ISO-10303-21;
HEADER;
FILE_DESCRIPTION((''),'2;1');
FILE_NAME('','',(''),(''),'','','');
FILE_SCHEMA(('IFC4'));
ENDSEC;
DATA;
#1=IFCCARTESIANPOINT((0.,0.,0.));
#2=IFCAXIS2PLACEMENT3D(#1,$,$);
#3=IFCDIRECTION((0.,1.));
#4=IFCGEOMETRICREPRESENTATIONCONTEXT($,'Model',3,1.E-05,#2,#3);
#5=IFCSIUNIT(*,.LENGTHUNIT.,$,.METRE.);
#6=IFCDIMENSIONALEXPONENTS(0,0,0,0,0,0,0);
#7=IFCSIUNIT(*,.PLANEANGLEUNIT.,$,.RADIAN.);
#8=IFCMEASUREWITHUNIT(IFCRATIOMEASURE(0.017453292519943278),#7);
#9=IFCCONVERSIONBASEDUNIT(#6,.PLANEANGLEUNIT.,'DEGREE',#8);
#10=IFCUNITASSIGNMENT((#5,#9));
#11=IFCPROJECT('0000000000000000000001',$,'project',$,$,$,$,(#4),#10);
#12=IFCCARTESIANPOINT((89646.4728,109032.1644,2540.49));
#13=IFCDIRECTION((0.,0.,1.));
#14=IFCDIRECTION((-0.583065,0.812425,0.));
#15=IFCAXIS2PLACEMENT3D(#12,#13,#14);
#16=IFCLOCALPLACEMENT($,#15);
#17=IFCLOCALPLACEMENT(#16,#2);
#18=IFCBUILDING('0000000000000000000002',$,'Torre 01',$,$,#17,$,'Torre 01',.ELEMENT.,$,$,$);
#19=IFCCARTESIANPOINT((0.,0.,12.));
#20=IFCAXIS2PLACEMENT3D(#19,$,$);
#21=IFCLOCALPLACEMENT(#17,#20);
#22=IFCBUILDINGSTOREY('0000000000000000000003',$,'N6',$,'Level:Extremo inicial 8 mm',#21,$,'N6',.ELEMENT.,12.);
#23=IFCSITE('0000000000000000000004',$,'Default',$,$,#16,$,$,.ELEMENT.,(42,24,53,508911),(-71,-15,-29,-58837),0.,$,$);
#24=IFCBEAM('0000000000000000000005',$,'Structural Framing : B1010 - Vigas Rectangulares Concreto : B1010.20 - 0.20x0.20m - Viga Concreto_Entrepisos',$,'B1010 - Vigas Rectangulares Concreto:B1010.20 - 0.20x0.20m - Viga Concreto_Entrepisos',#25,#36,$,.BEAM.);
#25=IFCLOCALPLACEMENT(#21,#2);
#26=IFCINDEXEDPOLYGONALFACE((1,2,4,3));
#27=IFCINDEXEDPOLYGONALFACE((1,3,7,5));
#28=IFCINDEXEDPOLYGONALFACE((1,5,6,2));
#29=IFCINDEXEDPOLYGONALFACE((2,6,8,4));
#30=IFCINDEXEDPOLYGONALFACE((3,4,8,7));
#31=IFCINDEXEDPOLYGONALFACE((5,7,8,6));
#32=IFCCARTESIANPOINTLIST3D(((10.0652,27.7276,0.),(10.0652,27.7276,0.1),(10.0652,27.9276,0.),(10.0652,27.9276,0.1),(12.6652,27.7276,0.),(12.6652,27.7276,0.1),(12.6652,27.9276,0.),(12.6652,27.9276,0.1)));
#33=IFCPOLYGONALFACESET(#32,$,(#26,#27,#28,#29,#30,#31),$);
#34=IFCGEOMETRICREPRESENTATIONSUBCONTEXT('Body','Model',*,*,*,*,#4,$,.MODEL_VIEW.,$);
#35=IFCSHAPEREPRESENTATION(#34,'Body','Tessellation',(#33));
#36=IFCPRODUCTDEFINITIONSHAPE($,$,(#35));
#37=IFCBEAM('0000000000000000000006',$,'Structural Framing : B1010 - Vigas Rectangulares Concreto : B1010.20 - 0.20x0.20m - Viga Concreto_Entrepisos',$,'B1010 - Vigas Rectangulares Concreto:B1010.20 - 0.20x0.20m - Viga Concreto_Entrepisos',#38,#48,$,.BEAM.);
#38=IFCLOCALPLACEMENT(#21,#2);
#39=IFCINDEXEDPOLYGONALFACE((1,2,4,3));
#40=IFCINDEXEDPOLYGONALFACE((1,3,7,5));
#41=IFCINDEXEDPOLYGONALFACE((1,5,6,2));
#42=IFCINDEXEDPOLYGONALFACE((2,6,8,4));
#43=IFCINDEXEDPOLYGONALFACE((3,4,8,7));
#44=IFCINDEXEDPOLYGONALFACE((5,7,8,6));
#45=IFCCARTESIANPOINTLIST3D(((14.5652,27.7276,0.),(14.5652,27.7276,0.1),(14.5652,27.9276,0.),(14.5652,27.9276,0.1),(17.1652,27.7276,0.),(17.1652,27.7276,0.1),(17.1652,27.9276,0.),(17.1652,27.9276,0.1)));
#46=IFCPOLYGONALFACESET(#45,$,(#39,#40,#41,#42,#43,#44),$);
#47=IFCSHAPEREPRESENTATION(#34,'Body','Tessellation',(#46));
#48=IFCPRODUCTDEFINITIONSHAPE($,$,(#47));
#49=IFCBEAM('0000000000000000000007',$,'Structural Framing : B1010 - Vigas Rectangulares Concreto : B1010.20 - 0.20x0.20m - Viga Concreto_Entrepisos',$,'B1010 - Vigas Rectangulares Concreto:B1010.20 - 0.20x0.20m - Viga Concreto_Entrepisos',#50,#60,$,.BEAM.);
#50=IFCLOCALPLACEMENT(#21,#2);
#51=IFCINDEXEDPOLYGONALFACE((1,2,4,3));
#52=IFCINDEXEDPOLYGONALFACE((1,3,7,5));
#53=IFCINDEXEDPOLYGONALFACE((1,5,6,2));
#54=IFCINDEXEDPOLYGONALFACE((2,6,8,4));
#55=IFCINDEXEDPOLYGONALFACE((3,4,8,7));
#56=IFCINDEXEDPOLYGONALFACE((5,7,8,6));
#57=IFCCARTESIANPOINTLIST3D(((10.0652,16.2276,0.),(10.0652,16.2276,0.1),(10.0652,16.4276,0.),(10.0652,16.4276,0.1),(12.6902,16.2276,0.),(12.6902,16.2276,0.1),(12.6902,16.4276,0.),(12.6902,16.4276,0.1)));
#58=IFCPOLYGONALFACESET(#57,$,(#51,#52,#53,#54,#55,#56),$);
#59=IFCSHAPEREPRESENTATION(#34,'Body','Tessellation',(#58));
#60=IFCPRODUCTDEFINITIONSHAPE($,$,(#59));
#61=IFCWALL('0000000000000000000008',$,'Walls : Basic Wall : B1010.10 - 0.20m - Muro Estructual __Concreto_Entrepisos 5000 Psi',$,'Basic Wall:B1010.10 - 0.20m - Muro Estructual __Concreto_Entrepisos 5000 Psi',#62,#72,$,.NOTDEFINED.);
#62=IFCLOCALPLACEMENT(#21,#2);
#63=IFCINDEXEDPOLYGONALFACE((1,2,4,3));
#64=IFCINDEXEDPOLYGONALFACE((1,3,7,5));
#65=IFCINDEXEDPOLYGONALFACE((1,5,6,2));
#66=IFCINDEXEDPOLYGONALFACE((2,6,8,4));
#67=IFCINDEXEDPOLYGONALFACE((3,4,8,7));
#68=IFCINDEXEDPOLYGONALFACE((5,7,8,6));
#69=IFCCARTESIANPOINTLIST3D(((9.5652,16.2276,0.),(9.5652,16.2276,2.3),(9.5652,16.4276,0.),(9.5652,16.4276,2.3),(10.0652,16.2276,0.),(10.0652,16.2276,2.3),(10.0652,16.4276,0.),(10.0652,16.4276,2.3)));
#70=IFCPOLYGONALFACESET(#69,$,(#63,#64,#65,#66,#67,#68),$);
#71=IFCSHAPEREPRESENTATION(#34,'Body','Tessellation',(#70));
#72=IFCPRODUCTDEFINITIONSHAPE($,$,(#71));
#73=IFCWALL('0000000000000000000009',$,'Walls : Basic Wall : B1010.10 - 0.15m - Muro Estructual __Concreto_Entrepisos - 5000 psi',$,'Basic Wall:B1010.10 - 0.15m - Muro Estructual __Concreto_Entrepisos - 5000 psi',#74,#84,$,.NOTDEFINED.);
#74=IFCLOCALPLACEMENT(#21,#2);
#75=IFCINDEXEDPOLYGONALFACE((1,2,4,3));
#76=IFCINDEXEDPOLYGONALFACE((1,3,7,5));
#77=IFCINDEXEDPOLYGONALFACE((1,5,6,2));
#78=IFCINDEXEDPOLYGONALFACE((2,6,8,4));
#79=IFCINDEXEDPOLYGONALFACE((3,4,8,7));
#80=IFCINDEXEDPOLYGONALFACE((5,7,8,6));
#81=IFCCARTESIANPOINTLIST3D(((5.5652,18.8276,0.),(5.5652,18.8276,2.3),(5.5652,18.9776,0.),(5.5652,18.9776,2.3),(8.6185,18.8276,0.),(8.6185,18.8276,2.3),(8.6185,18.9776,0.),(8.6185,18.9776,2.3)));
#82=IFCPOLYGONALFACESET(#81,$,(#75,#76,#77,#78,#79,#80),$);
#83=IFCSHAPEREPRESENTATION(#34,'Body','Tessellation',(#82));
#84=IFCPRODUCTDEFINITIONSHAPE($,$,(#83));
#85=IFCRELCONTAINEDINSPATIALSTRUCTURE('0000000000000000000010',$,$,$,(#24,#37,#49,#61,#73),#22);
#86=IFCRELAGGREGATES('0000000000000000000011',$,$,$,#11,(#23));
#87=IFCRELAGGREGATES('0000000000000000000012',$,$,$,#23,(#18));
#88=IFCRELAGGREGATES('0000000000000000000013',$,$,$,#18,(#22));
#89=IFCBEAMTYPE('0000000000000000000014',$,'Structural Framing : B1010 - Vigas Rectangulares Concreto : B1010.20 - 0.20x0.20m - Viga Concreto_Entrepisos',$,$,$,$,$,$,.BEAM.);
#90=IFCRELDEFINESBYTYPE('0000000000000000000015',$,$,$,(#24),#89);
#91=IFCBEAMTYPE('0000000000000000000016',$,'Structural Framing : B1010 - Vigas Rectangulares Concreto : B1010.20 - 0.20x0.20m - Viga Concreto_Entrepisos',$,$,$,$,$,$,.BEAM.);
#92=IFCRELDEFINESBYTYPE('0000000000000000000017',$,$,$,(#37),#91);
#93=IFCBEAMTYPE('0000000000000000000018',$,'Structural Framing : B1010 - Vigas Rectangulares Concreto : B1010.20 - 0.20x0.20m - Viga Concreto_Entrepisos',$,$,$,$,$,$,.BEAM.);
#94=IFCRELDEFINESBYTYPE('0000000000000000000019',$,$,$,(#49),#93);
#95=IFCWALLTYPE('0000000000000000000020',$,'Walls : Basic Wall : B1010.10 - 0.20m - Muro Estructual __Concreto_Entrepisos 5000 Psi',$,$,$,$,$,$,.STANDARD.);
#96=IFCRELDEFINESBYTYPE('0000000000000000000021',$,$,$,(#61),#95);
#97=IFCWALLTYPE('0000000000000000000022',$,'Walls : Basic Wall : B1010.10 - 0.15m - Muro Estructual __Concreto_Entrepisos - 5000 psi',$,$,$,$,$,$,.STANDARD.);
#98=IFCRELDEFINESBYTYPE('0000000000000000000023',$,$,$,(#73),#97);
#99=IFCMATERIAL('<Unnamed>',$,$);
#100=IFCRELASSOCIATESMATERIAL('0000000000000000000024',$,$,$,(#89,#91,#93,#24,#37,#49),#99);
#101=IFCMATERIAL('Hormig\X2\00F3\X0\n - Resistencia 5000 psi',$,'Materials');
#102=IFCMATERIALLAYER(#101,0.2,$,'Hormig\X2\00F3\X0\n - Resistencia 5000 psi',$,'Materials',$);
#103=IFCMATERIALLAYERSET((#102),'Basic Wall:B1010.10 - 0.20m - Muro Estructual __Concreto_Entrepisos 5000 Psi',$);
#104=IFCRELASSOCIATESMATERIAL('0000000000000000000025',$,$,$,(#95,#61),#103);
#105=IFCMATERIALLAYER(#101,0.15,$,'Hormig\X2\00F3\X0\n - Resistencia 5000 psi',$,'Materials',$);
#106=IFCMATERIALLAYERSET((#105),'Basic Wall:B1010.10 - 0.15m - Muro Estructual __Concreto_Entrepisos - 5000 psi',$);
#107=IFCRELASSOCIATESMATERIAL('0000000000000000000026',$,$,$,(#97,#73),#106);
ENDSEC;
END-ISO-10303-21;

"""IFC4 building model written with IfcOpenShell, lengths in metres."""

from ifc_helpers import new_model, entity, si_unit, converted_unit, direction, frame, frame_2d, origin, place, context, subcontext, project, spatial, polyline, segment, composite_curve, rectangle, outline, extrude, source, transform, mapped, material, layer, layer_set, layer_usage, material_profile, profile_set, profile_usage, type_object, type_shapes, element, save


model = new_model("IFC4")

# Units and contexts
model_context = context("Model", 3, precision=1e-05, world=origin(), true_north=direction((0.0, 1.0)))
body_context = subcontext(model_context, "Body", "Model", "MODEL_VIEW")
ifc_project = project(units=[si_unit("LENGTHUNIT", "METRE"), converted_unit("PLANEANGLEUNIT", "DEGREE", entity("IfcRatioMeasure", 0.017453292519943278), si_unit("PLANEANGLEUNIT", "RADIAN"), dimensions=[0, 0, 0, 0, 0, 0, 0])], contexts=[model_context])

# Site, building, storey
site_placement = place(None, frame((89646.4728, 109032.1644, 2540.49), z_axis=(0.0, 0.0, 1.0), x_axis=(-0.583065, 0.812425, 0.0)))
site = spatial("IfcSite", under=ifc_project, at=site_placement, Name="Default", CompositionType="ELEMENT", RefLatitude=(42, 24, 53, 508911), RefLongitude=(-71, -15, -29, -58837), RefElevation=0.0)
building_placement = place(site_placement, origin())
building = spatial("IfcBuilding", under=site, at=building_placement, Name="Torre 01", LongName="Torre 01", CompositionType="ELEMENT")
storey_placement = place(building_placement, frame((0.0, 0.0, 12.0)))
storey = spatial("IfcBuildingStorey", under=building, at=storey_placement, Name="N6", ObjectType="Level:Extremo inicial 8 mm", LongName="N6", CompositionType="ELEMENT", Elevation=12.0)

# Beams
ifc_material_1 = material(Name="<Unnamed>")
ifc_material_profile_1 = material_profile(ifc_material_1, outline(composite_curve([segment(polyline([(-0.1, 0.0, 0.0), (-0.1, 0.1, 0.0)]), True, "CONTINUOUS"), segment(polyline([(-0.1, 0.1, 0.0), (0.1, 0.1, 0.0)]), True, "CONTINUOUS"), segment(polyline([(0.1, 0.1, 0.0), (0.1, 0.0, 0.0)]), True, "CONTINUOUS"), segment(polyline([(0.1, 0.0, 0.0), (-0.1, 0.0, 0.0)]), True, "CONTINUOUS")], self_intersect=False), kind="CURVE"), Name="B1010.20 - 0.20x0.20m - Viga Concreto_Entrepisos")
ifc_material_profile_2 = material_profile(ifc_material_1, outline(composite_curve([segment(polyline([(-1.3, -0.1, 0.1), (-1.3, 0.1, 0.1)]), True, "CONTINUOUS"), segment(polyline([(-1.3, 0.1, 0.1), (-1.3, 0.1, -0.1)]), True, "CONTINUOUS"), segment(polyline([(-1.3, 0.1, -0.1), (-1.3, -0.1, -0.1)]), True, "CONTINUOUS"), segment(polyline([(-1.3, -0.1, -0.1), (-1.3, -0.1, 0.1)]), True, "CONTINUOUS")], self_intersect=False), kind="CURVE"), Name="B1010.20 - 0.20x0.20m - Viga Concreto_Entrepisos")
ifc_profile_set = profile_set([ifc_material_profile_1, ifc_material_profile_2], Name="B1010.20 - 0.20x0.20m - Viga Concreto_Entrepisos")
ifc_profile_usage_1 = profile_usage(ifc_profile_set, cardinal=8)
beam_type_1 = type_object("IfcBeamType", Name="Structural Framing : B1010 - Vigas Rectangulares Concreto : B1010.20 - 0.20x0.20m - Viga Concreto_Entrepisos", PredefinedType="BEAM", material=ifc_profile_set)
shared_shape_1 = source(origin(), body_context, "Body", "SweptSolid", [
    extrude(rectangle(XDim=0.1, YDim=0.2, at=frame_2d((0.0, 0.0), x_axis=(1.0, 0.0))), frame((10.0652, 27.8276, 12.05), z_axis=(1.0, 0.0, 0.0), x_axis=(0.0, 0.0, -1.0)), (0.0, 0.0, 1.0), 2.6),
])
type_shapes(beam_type_1, [shared_shape_1])
beam_1_placement = place(storey_placement, frame((0.0, 0.0, -12.0)))
element("IfcBeam", 1, at=beam_1_placement, inside=storey, type_object=beam_type_1, material=ifc_profile_usage_1, Name="Structural Framing : B1010 - Vigas Rectangulares Concreto : B1010.20 - 0.20x0.20m - Viga Concreto_Entrepisos", ObjectType="B1010 - Vigas Rectangulares Concreto:B1010.20 - 0.20x0.20m - Viga Concreto_Entrepisos", PredefinedType="BEAM", context=body_context, shape_type="MappedRepresentation", body=[
    mapped(shared_shape_1, transform((0.0, 0.0, 0.0), scale=1.0)),
])
ifc_profile_usage_2 = profile_usage(ifc_profile_set, cardinal=8)
beam_type_2 = type_object("IfcBeamType", Name="Structural Framing : B1010 - Vigas Rectangulares Concreto : B1010.20 - 0.20x0.20m - Viga Concreto_Entrepisos", PredefinedType="BEAM", material=ifc_profile_set)
shared_shape_2 = source(origin(), body_context, "Body", "SweptSolid", [
    extrude(rectangle(XDim=0.1, YDim=0.2, at=frame_2d((0.0, 0.0), x_axis=(1.0, 0.0))), frame((17.1652, 27.8276, 12.05), z_axis=(-1.0, 0.0, 0.0), x_axis=(0.0, 0.0, -1.0)), (0.0, 0.0, 1.0), 2.6),
])
type_shapes(beam_type_2, [shared_shape_2])
beam_2_placement = place(storey_placement, frame((0.0, 0.0, -12.0)))
element("IfcBeam", 2, at=beam_2_placement, inside=storey, type_object=beam_type_2, material=ifc_profile_usage_2, Name="Structural Framing : B1010 - Vigas Rectangulares Concreto : B1010.20 - 0.20x0.20m - Viga Concreto_Entrepisos", ObjectType="B1010 - Vigas Rectangulares Concreto:B1010.20 - 0.20x0.20m - Viga Concreto_Entrepisos", PredefinedType="BEAM", context=body_context, shape_type="MappedRepresentation", body=[
    mapped(shared_shape_2, transform((0.0, 0.0, 0.0), scale=1.0)),
])
ifc_profile_usage_3 = profile_usage(ifc_profile_set, cardinal=8)
beam_type_3 = type_object("IfcBeamType", Name="Structural Framing : B1010 - Vigas Rectangulares Concreto : B1010.20 - 0.20x0.20m - Viga Concreto_Entrepisos", PredefinedType="BEAM", material=ifc_profile_set)
shared_shape_3 = source(origin(), body_context, "Body", "SweptSolid", [
    extrude(rectangle(XDim=0.1, YDim=0.2, at=frame_2d((0.0, 0.0), x_axis=(1.0, 0.0))), frame((10.0652, 16.3276, 12.05), z_axis=(1.0, 0.0, 0.0), x_axis=(0.0, 0.0, -1.0)), (0.0, 0.0, 1.0), 2.625),
])
type_shapes(beam_type_3, [shared_shape_3])
beam_3_placement = place(storey_placement, frame((0.0, 0.0, -12.0)))
element("IfcBeam", 3, at=beam_3_placement, inside=storey, type_object=beam_type_3, material=ifc_profile_usage_3, Name="Structural Framing : B1010 - Vigas Rectangulares Concreto : B1010.20 - 0.20x0.20m - Viga Concreto_Entrepisos", ObjectType="B1010 - Vigas Rectangulares Concreto:B1010.20 - 0.20x0.20m - Viga Concreto_Entrepisos", PredefinedType="BEAM", context=body_context, shape_type="MappedRepresentation", body=[
    mapped(shared_shape_3, transform((0.0, 0.0, 0.0), scale=1.0)),
])

# Walls
ifc_material_2 = material(Name="Hormigón - Resistencia 5000 psi", Category="Materials")
ifc_layer_1 = layer(ifc_material_2, 0.2, Name="Hormigón - Resistencia 5000 psi", Category="Materials")
ifc_layer_set_1 = layer_set([ifc_layer_1], Name="Basic Wall:B1010.10 - 0.20m - Muro Estructual __Concreto_Entrepisos 5000 Psi")
ifc_layer_usage_1 = layer_usage(ifc_layer_set_1, "AXIS2", "NEGATIVE", 0.1)
wall_type_1 = type_object("IfcWallType", Name="Walls : Basic Wall : B1010.10 - 0.20m - Muro Estructual __Concreto_Entrepisos 5000 Psi", PredefinedType="STANDARD", material=ifc_layer_set_1)
wall_1_placement = place(storey_placement, frame((9.5652, 16.3276, 0.0)))
element("IfcWall", 4, at=wall_1_placement, inside=storey, type_object=wall_type_1, material=ifc_layer_usage_1, Name="Walls : Basic Wall : B1010.10 - 0.20m - Muro Estructual __Concreto_Entrepisos 5000 Psi", ObjectType="Basic Wall:B1010.10 - 0.20m - Muro Estructual __Concreto_Entrepisos 5000 Psi", PredefinedType="NOTDEFINED", context=body_context, shape_type="SweptSolid", body=[
    extrude(rectangle(XDim=0.5, YDim=0.2, at=frame_2d((0.25, 0.0), x_axis=(-1.0, 0.0))), origin(), (0.0, 0.0, 1.0), 2.3),
])
ifc_layer_2 = layer(ifc_material_2, 0.15, Name="Hormigón - Resistencia 5000 psi", Category="Materials")
ifc_layer_set_2 = layer_set([ifc_layer_2], Name="Basic Wall:B1010.10 - 0.15m - Muro Estructual __Concreto_Entrepisos - 5000 psi")
ifc_layer_usage_2 = layer_usage(ifc_layer_set_2, "AXIS2", "POSITIVE", -0.075)
wall_type_2 = type_object("IfcWallType", Name="Walls : Basic Wall : B1010.10 - 0.15m - Muro Estructual __Concreto_Entrepisos - 5000 psi", PredefinedType="STANDARD", material=ifc_layer_set_2)
wall_2_placement = place(storey_placement, frame((5.5652, 18.9026, 0.0)))
element("IfcWall", 5, at=wall_2_placement, inside=storey, type_object=wall_type_2, material=ifc_layer_usage_2, Name="Walls : Basic Wall : B1010.10 - 0.15m - Muro Estructual __Concreto_Entrepisos - 5000 psi", ObjectType="Basic Wall:B1010.10 - 0.15m - Muro Estructual __Concreto_Entrepisos - 5000 psi", PredefinedType="NOTDEFINED", context=body_context, shape_type="SweptSolid", body=[
    extrude(rectangle(XDim=3.0533, YDim=0.15, at=frame_2d((1.5267, 0.0), x_axis=(-1.0, 0.0))), origin(), (0.0, 0.0, 1.0), 2.3),
])

save(model, "model.ifc")
